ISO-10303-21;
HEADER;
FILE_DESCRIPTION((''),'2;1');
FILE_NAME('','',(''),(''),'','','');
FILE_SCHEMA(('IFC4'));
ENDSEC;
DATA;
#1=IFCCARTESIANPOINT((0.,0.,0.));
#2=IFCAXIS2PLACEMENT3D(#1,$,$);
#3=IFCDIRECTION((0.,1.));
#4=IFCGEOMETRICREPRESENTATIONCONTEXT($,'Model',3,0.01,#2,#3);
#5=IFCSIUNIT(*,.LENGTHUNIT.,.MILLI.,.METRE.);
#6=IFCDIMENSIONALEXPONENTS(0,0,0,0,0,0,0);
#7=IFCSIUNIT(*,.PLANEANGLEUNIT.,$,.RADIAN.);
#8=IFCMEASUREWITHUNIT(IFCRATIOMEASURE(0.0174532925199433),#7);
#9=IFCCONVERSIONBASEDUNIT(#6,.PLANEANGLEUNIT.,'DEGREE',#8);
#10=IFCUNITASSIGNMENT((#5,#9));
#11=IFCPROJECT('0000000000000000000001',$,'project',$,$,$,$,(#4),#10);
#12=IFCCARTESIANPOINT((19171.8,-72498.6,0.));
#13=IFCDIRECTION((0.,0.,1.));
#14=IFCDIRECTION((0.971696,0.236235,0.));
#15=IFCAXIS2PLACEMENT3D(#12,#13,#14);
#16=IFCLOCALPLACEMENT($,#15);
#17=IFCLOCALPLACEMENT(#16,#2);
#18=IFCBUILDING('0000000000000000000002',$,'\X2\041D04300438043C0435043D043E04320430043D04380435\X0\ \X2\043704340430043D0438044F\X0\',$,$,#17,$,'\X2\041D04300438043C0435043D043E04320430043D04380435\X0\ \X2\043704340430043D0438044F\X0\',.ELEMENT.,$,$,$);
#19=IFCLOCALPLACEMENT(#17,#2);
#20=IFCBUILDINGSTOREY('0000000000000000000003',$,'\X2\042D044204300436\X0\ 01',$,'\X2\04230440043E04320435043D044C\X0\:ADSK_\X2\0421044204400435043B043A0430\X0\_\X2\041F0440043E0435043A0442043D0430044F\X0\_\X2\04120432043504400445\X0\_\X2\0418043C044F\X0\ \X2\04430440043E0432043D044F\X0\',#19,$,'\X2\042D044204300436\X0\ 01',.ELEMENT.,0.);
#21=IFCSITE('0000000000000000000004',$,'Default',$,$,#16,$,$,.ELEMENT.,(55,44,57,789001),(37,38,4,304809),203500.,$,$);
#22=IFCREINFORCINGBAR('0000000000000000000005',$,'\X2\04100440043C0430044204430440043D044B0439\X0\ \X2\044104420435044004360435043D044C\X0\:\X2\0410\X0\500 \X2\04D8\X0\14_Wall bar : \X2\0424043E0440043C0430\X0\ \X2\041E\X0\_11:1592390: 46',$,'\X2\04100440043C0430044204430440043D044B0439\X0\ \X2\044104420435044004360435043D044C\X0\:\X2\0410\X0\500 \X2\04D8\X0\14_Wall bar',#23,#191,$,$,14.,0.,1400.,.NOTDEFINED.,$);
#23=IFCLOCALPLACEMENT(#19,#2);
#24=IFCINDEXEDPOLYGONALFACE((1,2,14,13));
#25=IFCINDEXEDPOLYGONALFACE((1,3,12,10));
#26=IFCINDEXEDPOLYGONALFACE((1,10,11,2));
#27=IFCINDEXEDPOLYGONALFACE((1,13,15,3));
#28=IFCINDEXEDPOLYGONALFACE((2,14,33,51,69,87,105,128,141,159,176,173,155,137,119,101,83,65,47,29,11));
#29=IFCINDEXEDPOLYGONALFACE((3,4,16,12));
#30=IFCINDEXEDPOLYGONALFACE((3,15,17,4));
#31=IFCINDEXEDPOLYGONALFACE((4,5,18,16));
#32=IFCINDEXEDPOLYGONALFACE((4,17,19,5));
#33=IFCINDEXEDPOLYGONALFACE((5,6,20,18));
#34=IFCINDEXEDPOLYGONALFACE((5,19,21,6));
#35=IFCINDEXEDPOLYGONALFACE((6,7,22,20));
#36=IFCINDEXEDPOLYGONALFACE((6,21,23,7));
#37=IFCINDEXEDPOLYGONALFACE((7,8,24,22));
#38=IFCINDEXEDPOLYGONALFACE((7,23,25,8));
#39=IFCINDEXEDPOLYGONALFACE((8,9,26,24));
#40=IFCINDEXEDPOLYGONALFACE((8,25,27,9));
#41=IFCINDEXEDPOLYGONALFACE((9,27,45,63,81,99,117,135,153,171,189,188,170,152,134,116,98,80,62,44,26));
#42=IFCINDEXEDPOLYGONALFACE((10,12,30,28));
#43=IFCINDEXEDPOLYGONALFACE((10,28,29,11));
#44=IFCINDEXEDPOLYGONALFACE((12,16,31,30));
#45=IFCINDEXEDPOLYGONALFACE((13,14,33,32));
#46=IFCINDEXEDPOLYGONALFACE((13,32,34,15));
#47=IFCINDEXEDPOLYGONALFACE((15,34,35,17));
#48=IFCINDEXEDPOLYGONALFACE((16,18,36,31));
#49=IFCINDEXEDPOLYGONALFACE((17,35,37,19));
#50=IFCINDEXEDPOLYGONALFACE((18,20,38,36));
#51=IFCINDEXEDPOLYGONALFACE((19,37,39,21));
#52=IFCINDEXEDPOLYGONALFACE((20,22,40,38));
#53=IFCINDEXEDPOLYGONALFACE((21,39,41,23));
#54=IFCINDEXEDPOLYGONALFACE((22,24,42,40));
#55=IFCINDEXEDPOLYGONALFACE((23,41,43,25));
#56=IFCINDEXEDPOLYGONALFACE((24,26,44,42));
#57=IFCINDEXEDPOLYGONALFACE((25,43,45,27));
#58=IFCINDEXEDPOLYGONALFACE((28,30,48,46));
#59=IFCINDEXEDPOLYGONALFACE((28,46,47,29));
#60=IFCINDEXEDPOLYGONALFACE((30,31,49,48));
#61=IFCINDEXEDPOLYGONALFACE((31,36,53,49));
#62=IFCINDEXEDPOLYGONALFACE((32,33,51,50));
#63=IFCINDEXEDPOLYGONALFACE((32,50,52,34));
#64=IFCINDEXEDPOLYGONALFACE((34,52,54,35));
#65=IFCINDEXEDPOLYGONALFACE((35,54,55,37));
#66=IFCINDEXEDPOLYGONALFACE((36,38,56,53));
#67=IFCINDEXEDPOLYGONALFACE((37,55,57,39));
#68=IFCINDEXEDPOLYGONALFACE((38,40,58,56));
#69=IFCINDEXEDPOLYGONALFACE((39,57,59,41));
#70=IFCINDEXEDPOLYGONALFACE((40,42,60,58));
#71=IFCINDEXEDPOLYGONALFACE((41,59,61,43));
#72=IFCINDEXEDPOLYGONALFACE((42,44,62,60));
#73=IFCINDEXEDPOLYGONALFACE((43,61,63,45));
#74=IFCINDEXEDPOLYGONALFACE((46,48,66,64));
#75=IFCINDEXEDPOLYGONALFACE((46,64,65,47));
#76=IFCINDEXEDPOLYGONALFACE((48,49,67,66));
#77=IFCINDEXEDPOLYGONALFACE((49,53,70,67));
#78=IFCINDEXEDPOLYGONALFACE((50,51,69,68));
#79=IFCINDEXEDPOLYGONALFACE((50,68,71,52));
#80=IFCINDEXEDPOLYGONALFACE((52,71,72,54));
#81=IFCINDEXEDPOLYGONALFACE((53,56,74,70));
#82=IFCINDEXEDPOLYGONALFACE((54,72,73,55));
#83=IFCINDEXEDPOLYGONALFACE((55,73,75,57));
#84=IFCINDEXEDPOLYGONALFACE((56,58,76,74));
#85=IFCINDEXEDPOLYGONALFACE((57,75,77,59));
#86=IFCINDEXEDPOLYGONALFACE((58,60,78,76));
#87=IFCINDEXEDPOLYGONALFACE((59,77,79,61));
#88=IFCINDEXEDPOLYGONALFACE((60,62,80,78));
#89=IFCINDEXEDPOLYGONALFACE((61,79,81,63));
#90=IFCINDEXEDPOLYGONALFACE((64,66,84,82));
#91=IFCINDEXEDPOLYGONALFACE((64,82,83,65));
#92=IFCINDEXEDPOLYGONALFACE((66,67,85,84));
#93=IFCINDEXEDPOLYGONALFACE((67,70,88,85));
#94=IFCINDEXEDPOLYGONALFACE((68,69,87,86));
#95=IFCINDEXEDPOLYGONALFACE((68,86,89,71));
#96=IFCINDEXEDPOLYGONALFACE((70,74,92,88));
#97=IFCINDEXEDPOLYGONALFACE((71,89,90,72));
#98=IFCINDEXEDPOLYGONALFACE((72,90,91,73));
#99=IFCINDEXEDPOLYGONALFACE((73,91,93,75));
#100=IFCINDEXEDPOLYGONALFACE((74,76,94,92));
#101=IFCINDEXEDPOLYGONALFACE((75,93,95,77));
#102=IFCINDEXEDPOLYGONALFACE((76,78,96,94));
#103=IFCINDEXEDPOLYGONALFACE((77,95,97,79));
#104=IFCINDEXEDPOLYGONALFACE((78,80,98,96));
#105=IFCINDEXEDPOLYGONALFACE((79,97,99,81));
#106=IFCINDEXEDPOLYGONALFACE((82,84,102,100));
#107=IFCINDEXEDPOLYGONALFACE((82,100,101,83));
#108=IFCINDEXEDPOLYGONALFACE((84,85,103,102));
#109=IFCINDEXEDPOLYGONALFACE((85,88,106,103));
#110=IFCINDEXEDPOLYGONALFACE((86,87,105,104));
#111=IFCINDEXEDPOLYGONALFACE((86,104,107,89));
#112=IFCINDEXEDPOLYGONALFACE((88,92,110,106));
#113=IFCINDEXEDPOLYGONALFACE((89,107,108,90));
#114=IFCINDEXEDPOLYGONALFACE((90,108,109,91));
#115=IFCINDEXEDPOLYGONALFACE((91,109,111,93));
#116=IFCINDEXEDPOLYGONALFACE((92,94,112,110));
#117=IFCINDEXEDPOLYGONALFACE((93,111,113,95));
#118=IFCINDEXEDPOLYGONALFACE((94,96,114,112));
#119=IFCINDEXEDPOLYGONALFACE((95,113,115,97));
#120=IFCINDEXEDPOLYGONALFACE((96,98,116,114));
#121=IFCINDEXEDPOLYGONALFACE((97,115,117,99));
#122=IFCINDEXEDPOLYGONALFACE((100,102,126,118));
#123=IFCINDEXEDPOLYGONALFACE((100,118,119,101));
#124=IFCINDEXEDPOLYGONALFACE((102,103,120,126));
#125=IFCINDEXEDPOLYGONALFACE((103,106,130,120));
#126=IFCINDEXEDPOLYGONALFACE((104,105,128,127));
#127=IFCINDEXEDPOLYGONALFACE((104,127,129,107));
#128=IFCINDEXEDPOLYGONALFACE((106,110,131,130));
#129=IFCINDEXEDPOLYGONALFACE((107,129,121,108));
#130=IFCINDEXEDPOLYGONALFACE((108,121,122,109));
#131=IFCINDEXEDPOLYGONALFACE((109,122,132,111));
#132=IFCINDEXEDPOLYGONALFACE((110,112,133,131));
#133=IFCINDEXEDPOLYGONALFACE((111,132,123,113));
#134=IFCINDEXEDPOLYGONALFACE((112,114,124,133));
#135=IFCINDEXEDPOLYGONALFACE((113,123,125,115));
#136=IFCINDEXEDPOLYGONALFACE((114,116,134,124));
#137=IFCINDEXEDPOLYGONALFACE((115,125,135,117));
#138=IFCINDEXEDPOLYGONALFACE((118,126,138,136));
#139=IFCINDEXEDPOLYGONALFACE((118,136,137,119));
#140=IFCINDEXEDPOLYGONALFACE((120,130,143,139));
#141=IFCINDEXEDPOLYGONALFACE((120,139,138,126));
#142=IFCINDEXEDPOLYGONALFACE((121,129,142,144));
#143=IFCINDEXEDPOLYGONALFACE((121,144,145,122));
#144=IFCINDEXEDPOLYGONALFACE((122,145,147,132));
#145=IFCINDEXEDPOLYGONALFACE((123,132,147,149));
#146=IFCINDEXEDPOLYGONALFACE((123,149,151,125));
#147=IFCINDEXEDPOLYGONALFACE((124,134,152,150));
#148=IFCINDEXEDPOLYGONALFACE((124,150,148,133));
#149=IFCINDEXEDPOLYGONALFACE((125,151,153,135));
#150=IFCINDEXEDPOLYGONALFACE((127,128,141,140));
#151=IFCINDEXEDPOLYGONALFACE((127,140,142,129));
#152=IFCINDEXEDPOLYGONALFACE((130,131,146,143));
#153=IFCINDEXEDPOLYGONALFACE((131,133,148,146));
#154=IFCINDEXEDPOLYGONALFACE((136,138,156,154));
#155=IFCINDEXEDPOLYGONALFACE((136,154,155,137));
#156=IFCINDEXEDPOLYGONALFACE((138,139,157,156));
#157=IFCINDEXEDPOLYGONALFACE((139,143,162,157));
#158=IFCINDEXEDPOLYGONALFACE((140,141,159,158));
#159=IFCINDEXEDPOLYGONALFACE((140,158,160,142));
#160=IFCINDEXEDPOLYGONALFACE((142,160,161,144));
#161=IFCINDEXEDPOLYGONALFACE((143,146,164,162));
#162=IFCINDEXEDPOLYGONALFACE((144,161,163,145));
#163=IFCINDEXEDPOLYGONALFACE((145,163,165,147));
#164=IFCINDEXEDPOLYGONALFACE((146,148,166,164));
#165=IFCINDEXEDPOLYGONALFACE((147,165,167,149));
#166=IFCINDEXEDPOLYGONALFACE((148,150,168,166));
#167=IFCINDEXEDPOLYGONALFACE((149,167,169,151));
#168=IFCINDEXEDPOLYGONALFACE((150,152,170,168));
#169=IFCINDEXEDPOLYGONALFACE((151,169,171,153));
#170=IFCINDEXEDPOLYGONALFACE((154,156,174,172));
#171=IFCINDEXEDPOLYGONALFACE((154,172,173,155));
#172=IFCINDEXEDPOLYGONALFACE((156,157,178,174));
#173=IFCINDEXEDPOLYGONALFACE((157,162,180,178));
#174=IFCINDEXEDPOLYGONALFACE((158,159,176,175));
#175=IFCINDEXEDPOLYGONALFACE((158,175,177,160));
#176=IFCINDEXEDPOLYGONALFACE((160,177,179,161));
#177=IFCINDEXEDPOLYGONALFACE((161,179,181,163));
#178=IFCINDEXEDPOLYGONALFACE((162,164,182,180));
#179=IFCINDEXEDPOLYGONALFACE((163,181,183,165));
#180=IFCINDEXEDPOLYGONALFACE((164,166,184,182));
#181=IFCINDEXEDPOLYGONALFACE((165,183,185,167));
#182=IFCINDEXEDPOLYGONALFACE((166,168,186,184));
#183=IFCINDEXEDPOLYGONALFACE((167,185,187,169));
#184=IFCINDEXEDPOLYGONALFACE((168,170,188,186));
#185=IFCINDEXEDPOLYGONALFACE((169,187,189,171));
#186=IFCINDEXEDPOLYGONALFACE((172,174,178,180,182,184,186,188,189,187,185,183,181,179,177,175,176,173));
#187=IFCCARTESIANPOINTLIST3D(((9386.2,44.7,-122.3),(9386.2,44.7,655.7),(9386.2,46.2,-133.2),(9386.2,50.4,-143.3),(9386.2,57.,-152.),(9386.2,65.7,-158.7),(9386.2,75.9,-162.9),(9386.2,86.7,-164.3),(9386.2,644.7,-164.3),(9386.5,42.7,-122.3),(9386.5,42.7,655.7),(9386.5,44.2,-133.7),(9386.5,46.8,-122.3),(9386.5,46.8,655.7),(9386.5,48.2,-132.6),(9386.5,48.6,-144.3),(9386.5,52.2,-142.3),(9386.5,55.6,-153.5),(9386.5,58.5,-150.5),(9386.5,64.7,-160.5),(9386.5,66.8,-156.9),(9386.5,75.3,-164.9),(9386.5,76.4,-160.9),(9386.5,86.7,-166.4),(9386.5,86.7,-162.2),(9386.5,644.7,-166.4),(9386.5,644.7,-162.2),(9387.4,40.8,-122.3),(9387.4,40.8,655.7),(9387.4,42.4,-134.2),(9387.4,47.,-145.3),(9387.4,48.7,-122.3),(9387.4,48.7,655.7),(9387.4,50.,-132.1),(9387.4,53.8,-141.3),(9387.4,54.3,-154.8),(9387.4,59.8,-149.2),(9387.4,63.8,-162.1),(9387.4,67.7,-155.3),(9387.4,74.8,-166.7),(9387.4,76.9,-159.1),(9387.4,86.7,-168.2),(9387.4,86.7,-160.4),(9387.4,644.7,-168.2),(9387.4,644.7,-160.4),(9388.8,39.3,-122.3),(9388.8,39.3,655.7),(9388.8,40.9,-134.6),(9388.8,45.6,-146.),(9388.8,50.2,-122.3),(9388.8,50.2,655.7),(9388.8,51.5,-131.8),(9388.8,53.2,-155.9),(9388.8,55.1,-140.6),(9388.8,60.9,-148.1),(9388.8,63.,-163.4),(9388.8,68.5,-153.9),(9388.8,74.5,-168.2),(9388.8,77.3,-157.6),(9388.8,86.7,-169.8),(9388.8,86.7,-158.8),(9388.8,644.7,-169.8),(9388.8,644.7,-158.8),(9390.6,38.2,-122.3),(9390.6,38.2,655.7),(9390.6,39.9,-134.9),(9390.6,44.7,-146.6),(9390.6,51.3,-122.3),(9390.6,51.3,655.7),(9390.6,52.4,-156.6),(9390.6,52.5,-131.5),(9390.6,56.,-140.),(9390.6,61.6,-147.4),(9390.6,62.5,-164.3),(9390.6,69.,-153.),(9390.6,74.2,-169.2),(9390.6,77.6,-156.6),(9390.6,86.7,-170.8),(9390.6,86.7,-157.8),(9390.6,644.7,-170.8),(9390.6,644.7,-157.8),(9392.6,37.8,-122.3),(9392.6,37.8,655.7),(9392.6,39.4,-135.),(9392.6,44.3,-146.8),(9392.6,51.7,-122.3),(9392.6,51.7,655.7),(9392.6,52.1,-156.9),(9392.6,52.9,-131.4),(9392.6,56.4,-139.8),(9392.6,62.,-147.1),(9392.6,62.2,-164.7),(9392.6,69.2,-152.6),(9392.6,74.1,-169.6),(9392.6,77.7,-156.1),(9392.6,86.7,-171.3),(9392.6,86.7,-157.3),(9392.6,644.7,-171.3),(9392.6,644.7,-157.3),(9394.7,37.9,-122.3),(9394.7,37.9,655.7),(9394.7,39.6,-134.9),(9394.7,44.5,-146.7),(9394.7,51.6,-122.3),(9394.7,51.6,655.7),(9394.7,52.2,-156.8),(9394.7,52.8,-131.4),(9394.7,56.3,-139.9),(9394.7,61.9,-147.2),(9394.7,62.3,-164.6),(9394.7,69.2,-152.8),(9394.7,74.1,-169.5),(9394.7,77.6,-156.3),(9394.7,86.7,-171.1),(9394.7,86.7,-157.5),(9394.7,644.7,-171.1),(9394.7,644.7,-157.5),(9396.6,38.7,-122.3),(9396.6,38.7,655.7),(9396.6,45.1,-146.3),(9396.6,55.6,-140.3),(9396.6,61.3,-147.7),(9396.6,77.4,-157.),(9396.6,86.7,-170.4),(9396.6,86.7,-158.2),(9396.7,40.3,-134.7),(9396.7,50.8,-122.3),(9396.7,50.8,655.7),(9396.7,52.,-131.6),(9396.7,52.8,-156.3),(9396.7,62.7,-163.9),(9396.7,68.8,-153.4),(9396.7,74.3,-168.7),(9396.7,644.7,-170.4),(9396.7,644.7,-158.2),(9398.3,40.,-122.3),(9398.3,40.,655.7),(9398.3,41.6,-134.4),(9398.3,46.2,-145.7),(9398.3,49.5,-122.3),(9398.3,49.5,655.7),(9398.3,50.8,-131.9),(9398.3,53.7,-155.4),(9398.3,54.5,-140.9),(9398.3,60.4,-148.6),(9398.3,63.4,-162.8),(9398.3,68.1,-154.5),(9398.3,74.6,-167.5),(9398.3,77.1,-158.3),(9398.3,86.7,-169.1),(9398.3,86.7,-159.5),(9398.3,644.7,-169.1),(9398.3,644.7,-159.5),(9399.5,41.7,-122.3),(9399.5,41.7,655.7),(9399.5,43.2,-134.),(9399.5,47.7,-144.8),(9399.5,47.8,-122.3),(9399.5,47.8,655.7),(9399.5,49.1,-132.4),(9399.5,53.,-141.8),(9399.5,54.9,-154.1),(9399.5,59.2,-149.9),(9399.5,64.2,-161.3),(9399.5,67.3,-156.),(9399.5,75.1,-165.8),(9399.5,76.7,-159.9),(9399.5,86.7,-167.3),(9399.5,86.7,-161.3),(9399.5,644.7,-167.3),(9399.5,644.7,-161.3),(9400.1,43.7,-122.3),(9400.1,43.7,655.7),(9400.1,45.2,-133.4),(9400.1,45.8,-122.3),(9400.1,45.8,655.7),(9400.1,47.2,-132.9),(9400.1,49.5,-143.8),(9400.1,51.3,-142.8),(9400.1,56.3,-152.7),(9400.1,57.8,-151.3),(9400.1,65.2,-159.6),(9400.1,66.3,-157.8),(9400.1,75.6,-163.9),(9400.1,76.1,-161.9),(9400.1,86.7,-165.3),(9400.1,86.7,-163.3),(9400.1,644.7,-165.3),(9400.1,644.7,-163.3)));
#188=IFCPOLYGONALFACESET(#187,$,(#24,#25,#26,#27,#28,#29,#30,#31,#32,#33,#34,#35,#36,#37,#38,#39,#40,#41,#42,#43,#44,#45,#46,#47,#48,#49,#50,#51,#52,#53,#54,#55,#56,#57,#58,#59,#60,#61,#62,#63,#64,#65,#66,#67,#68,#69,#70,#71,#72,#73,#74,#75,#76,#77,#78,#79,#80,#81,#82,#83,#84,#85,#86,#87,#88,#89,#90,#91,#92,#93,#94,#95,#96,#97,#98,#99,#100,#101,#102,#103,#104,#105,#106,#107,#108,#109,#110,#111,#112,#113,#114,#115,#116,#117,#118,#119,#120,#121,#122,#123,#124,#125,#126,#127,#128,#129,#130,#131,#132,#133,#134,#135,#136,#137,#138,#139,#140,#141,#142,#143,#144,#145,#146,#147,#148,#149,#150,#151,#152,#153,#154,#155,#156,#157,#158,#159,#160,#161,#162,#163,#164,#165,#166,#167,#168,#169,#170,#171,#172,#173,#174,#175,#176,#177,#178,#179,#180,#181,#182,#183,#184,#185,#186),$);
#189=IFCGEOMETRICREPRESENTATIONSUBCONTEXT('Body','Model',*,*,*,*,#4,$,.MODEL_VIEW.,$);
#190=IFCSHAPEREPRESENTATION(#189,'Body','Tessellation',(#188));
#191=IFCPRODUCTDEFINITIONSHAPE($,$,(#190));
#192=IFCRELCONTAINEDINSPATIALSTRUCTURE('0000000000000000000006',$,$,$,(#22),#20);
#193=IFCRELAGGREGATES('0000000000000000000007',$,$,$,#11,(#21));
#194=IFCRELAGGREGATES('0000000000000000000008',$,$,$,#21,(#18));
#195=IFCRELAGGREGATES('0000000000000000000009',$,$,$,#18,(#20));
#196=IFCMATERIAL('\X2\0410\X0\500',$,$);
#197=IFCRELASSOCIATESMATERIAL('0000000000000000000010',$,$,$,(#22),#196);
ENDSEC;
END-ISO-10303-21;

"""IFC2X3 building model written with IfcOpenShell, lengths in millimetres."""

from ifc_helpers import new_model, entity, si_unit, converted_unit, direction, frame, origin, place, context, subcontext, project, spatial, material, element, save


model = new_model("IFC2X3")

# Units and contexts
model_context = context("Model", 3, precision=0.01, world=origin(), true_north=direction((0.0, 1.0)))
body_context = subcontext(model_context, "Body", "Model", "MODEL_VIEW")
ifc_project = project(units=[si_unit("LENGTHUNIT", "METRE", prefix="MILLI"), converted_unit("PLANEANGLEUNIT", "DEGREE", entity("IfcRatioMeasure", 0.0174532925199433), si_unit("PLANEANGLEUNIT", "RADIAN"), dimensions=[0, 0, 0, 0, 0, 0, 0])], contexts=[model_context])

# Site, building, storey
site_placement = place(None, frame((19171.8, -72498.6, 0.0), z_axis=(0.0, 0.0, 1.0), x_axis=(0.971696, 0.236235, 0.0)))
site = spatial("IfcSite", under=ifc_project, at=site_placement, Name="Default", CompositionType="ELEMENT", RefLatitude=(55, 44, 57, 789001), RefLongitude=(37, 38, 4, 304809), RefElevation=203500.0)
building_placement = place(site_placement, origin())
building = spatial("IfcBuilding", under=site, at=building_placement, Name="Наименование здания", LongName="Наименование здания", CompositionType="ELEMENT")
storey_placement = place(building_placement, origin())
storey = spatial("IfcBuildingStorey", under=building, at=storey_placement, Name="Этаж 01", ObjectType="Уровень:ADSK_Стрелка_Проектная_Вверх_Имя уровня", LongName="Этаж 01", CompositionType="ELEMENT", Elevation=0.0)

# Reinforcing bar
ifc_material = material(Name="А500")
placement = place(storey_placement, origin())
element("IfcReinforcingBar", 1, at=placement, inside=storey, material=ifc_material, Name="Арматурный стержень:А500 Ә14_Wall bar : Форма О_11:1592390: 46", ObjectType="Арматурный стержень:А500 Ә14_Wall bar", BarLength=1400.0, BarRole="NOTDEFINED", CrossSectionArea=0.0, NominalDiameter=14.0, context=body_context, shape_type="AdvancedSweptSolid", body=[
    entity("IfcSweptDiskSolid", entity("IfcCompositeCurve", [entity("IfcCompositeCurveSegment", "CONTINUOUS", True, entity("IfcPolyline", [entity("IfcCartesianPoint", [9393.1, 44.7, 655.7]), entity("IfcCartesianPoint", [9393.1, 44.7, -122.3])])), entity("IfcCompositeCurveSegment", "CONTINUOUS", True, entity("IfcTrimmedCurve", entity("IfcCircle", entity("IfcAxis2Placement3D", entity("IfcCartesianPoint", [9393.1, 86.7, -122.3]), entity("IfcDirection", [1.0, 0.0, 0.0]), entity("IfcDirection", [0.0, 0.0, -1.0])), 42.0), [entity("IfcParameterValue", 270.0)], [entity("IfcParameterValue", 360.0)], True, "PARAMETER")), entity("IfcCompositeCurveSegment", "CONTINUOUS", True, entity("IfcPolyline", [entity("IfcCartesianPoint", [9393.1, 86.7, -164.3]), entity("IfcCartesianPoint", [9393.1, 644.7, -164.3])]))], False), 7.0, None, 0.0, 92.0),
])

save(model, "model.ifc")
